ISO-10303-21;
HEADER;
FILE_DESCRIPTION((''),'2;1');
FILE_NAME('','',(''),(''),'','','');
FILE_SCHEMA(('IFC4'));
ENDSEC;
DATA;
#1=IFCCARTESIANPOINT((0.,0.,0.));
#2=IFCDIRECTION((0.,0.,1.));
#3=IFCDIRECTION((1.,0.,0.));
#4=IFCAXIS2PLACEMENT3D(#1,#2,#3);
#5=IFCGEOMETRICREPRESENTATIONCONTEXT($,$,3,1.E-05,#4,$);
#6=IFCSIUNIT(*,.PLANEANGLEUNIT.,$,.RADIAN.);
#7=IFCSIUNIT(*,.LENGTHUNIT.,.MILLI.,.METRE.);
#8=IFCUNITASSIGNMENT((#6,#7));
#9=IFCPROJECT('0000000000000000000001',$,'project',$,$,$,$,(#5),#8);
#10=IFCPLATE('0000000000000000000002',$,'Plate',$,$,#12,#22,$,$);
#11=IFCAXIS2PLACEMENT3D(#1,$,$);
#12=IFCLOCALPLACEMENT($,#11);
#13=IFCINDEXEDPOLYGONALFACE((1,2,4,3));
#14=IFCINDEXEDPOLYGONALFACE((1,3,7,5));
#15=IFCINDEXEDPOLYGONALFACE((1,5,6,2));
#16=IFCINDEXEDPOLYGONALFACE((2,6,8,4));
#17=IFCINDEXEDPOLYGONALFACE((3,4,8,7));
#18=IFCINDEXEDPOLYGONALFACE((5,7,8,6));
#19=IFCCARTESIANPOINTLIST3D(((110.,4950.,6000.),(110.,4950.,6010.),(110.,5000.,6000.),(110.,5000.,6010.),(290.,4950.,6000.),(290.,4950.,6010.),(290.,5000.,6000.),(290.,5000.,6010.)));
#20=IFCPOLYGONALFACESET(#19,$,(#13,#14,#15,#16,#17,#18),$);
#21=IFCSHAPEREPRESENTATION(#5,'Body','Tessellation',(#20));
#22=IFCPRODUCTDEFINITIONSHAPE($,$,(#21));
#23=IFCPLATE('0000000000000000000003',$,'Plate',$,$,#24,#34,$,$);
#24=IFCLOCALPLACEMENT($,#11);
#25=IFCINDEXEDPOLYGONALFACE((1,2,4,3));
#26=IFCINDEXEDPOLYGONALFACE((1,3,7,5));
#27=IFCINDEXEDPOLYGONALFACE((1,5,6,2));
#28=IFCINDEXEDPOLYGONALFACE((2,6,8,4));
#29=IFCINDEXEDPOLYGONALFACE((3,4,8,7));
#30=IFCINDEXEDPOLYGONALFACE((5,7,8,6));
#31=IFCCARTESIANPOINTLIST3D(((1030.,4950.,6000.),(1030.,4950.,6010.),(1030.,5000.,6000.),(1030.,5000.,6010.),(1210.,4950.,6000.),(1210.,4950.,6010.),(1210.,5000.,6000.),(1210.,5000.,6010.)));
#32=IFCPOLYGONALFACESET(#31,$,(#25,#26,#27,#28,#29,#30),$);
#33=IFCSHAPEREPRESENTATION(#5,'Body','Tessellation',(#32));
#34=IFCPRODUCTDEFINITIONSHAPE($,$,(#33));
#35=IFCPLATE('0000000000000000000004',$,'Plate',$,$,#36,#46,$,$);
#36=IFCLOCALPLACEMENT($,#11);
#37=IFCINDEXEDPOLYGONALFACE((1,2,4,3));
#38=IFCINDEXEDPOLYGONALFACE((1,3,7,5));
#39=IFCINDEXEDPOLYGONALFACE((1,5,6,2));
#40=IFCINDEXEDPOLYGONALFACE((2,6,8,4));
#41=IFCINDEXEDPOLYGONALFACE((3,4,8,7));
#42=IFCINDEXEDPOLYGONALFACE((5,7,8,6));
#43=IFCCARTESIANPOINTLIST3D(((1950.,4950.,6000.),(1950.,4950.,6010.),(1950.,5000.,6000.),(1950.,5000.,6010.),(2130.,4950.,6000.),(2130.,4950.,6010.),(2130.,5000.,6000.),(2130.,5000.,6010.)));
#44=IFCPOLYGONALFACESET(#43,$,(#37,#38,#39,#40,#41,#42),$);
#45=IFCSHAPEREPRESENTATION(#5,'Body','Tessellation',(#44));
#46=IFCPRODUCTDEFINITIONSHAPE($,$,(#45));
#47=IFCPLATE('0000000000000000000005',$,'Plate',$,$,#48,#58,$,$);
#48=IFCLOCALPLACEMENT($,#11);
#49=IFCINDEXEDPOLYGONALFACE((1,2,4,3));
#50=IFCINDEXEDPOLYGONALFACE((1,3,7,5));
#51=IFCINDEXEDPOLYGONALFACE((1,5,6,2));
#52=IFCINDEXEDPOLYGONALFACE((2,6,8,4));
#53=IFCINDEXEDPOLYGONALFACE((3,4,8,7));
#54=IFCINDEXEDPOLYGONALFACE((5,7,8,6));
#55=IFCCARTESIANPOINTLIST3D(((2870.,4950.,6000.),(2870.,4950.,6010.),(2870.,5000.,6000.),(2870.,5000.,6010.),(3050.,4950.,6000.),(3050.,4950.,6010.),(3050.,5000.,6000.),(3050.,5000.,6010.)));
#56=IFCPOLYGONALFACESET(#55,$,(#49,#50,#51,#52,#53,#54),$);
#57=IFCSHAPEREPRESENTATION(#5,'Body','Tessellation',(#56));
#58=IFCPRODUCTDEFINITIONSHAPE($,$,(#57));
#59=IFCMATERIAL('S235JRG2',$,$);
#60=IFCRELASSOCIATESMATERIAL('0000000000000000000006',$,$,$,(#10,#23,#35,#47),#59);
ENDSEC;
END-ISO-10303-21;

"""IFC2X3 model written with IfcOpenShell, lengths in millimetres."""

from ifc_helpers import new_model, si_unit, frame, origin_with_axes, place, context, project, polyline, outline, extrude, material, element, save


model = new_model("IFC2X3")

# Units and contexts
context_of_model = context(None, 3, precision=1e-05, world=origin_with_axes())
ifc_project = project(units=[si_unit("PLANEANGLEUNIT", "RADIAN"), si_unit("LENGTHUNIT", "METRE", prefix="MILLI")], contexts=[context_of_model])

# Shared definitions
ifc_material = material(Name="S235JRG2")

# Plates
placement_1 = place(None, origin_with_axes())
plate_1_placement = place(placement_1, frame((110.0, 5000.0, 6010.0), z_axis=(0.0, -1.0, 0.0), x_axis=(0.0, 0.0, -1.0)))
element("IfcPlate", 1, at=plate_1_placement, material=ifc_material, Name="Plate", context=context_of_model, shape_type="SweptSolid", body=[
    extrude(outline(polyline([(0.0, 0.0), (180.0, 0.0), (180.0, 50.0), (0.0, 50.0), (0.0, 0.0)])), frame((0.0, 0.0, 0.0), z_axis=(1.0, 0.0, 0.0), x_axis=(0.0, 1.0, 0.0)), (0.0, 0.0, 1.0), 10.0),
])
placement_2 = place(None, origin_with_axes())
plate_2_placement = place(placement_2, frame((1030.0, 5000.0, 6010.0), z_axis=(0.0, -1.0, 0.0), x_axis=(0.0, 0.0, -1.0)))
element("IfcPlate", 2, at=plate_2_placement, material=ifc_material, Name="Plate", context=context_of_model, shape_type="SweptSolid", body=[
    extrude(outline(polyline([(0.0, 0.0), (180.0, 0.0), (180.0, 50.0), (0.0, 50.0), (0.0, 0.0)])), frame((0.0, 0.0, 0.0), z_axis=(1.0, 0.0, 0.0), x_axis=(0.0, 1.0, 0.0)), (0.0, 0.0, 1.0), 10.0),
])
placement_3 = place(None, origin_with_axes())
plate_3_placement = place(placement_3, frame((1950.0, 5000.0, 6010.0), z_axis=(0.0, -1.0, 0.0), x_axis=(0.0, 0.0, -1.0)))
element("IfcPlate", 3, at=plate_3_placement, material=ifc_material, Name="Plate", context=context_of_model, shape_type="SweptSolid", body=[
    extrude(outline(polyline([(0.0, 0.0), (180.0, 0.0), (180.0, 50.0), (0.0, 50.0), (0.0, 0.0)])), frame((0.0, 0.0, 0.0), z_axis=(1.0, 0.0, 0.0), x_axis=(0.0, 1.0, 0.0)), (0.0, 0.0, 1.0), 10.0),
])
placement_4 = place(None, origin_with_axes())
plate_4_placement = place(placement_4, frame((2870.0, 5000.0, 6010.0), z_axis=(0.0, -1.0, 0.0), x_axis=(0.0, 0.0, -1.0)))
element("IfcPlate", 4, at=plate_4_placement, material=ifc_material, Name="Plate", context=context_of_model, shape_type="SweptSolid", body=[
    extrude(outline(polyline([(0.0, 0.0), (180.0, 0.0), (180.0, 50.0), (0.0, 50.0), (0.0, 0.0)])), frame((0.0, 0.0, 0.0), z_axis=(1.0, 0.0, 0.0), x_axis=(0.0, 1.0, 0.0)), (0.0, 0.0, 1.0), 10.0),
])

save(model, "model.ifc")
